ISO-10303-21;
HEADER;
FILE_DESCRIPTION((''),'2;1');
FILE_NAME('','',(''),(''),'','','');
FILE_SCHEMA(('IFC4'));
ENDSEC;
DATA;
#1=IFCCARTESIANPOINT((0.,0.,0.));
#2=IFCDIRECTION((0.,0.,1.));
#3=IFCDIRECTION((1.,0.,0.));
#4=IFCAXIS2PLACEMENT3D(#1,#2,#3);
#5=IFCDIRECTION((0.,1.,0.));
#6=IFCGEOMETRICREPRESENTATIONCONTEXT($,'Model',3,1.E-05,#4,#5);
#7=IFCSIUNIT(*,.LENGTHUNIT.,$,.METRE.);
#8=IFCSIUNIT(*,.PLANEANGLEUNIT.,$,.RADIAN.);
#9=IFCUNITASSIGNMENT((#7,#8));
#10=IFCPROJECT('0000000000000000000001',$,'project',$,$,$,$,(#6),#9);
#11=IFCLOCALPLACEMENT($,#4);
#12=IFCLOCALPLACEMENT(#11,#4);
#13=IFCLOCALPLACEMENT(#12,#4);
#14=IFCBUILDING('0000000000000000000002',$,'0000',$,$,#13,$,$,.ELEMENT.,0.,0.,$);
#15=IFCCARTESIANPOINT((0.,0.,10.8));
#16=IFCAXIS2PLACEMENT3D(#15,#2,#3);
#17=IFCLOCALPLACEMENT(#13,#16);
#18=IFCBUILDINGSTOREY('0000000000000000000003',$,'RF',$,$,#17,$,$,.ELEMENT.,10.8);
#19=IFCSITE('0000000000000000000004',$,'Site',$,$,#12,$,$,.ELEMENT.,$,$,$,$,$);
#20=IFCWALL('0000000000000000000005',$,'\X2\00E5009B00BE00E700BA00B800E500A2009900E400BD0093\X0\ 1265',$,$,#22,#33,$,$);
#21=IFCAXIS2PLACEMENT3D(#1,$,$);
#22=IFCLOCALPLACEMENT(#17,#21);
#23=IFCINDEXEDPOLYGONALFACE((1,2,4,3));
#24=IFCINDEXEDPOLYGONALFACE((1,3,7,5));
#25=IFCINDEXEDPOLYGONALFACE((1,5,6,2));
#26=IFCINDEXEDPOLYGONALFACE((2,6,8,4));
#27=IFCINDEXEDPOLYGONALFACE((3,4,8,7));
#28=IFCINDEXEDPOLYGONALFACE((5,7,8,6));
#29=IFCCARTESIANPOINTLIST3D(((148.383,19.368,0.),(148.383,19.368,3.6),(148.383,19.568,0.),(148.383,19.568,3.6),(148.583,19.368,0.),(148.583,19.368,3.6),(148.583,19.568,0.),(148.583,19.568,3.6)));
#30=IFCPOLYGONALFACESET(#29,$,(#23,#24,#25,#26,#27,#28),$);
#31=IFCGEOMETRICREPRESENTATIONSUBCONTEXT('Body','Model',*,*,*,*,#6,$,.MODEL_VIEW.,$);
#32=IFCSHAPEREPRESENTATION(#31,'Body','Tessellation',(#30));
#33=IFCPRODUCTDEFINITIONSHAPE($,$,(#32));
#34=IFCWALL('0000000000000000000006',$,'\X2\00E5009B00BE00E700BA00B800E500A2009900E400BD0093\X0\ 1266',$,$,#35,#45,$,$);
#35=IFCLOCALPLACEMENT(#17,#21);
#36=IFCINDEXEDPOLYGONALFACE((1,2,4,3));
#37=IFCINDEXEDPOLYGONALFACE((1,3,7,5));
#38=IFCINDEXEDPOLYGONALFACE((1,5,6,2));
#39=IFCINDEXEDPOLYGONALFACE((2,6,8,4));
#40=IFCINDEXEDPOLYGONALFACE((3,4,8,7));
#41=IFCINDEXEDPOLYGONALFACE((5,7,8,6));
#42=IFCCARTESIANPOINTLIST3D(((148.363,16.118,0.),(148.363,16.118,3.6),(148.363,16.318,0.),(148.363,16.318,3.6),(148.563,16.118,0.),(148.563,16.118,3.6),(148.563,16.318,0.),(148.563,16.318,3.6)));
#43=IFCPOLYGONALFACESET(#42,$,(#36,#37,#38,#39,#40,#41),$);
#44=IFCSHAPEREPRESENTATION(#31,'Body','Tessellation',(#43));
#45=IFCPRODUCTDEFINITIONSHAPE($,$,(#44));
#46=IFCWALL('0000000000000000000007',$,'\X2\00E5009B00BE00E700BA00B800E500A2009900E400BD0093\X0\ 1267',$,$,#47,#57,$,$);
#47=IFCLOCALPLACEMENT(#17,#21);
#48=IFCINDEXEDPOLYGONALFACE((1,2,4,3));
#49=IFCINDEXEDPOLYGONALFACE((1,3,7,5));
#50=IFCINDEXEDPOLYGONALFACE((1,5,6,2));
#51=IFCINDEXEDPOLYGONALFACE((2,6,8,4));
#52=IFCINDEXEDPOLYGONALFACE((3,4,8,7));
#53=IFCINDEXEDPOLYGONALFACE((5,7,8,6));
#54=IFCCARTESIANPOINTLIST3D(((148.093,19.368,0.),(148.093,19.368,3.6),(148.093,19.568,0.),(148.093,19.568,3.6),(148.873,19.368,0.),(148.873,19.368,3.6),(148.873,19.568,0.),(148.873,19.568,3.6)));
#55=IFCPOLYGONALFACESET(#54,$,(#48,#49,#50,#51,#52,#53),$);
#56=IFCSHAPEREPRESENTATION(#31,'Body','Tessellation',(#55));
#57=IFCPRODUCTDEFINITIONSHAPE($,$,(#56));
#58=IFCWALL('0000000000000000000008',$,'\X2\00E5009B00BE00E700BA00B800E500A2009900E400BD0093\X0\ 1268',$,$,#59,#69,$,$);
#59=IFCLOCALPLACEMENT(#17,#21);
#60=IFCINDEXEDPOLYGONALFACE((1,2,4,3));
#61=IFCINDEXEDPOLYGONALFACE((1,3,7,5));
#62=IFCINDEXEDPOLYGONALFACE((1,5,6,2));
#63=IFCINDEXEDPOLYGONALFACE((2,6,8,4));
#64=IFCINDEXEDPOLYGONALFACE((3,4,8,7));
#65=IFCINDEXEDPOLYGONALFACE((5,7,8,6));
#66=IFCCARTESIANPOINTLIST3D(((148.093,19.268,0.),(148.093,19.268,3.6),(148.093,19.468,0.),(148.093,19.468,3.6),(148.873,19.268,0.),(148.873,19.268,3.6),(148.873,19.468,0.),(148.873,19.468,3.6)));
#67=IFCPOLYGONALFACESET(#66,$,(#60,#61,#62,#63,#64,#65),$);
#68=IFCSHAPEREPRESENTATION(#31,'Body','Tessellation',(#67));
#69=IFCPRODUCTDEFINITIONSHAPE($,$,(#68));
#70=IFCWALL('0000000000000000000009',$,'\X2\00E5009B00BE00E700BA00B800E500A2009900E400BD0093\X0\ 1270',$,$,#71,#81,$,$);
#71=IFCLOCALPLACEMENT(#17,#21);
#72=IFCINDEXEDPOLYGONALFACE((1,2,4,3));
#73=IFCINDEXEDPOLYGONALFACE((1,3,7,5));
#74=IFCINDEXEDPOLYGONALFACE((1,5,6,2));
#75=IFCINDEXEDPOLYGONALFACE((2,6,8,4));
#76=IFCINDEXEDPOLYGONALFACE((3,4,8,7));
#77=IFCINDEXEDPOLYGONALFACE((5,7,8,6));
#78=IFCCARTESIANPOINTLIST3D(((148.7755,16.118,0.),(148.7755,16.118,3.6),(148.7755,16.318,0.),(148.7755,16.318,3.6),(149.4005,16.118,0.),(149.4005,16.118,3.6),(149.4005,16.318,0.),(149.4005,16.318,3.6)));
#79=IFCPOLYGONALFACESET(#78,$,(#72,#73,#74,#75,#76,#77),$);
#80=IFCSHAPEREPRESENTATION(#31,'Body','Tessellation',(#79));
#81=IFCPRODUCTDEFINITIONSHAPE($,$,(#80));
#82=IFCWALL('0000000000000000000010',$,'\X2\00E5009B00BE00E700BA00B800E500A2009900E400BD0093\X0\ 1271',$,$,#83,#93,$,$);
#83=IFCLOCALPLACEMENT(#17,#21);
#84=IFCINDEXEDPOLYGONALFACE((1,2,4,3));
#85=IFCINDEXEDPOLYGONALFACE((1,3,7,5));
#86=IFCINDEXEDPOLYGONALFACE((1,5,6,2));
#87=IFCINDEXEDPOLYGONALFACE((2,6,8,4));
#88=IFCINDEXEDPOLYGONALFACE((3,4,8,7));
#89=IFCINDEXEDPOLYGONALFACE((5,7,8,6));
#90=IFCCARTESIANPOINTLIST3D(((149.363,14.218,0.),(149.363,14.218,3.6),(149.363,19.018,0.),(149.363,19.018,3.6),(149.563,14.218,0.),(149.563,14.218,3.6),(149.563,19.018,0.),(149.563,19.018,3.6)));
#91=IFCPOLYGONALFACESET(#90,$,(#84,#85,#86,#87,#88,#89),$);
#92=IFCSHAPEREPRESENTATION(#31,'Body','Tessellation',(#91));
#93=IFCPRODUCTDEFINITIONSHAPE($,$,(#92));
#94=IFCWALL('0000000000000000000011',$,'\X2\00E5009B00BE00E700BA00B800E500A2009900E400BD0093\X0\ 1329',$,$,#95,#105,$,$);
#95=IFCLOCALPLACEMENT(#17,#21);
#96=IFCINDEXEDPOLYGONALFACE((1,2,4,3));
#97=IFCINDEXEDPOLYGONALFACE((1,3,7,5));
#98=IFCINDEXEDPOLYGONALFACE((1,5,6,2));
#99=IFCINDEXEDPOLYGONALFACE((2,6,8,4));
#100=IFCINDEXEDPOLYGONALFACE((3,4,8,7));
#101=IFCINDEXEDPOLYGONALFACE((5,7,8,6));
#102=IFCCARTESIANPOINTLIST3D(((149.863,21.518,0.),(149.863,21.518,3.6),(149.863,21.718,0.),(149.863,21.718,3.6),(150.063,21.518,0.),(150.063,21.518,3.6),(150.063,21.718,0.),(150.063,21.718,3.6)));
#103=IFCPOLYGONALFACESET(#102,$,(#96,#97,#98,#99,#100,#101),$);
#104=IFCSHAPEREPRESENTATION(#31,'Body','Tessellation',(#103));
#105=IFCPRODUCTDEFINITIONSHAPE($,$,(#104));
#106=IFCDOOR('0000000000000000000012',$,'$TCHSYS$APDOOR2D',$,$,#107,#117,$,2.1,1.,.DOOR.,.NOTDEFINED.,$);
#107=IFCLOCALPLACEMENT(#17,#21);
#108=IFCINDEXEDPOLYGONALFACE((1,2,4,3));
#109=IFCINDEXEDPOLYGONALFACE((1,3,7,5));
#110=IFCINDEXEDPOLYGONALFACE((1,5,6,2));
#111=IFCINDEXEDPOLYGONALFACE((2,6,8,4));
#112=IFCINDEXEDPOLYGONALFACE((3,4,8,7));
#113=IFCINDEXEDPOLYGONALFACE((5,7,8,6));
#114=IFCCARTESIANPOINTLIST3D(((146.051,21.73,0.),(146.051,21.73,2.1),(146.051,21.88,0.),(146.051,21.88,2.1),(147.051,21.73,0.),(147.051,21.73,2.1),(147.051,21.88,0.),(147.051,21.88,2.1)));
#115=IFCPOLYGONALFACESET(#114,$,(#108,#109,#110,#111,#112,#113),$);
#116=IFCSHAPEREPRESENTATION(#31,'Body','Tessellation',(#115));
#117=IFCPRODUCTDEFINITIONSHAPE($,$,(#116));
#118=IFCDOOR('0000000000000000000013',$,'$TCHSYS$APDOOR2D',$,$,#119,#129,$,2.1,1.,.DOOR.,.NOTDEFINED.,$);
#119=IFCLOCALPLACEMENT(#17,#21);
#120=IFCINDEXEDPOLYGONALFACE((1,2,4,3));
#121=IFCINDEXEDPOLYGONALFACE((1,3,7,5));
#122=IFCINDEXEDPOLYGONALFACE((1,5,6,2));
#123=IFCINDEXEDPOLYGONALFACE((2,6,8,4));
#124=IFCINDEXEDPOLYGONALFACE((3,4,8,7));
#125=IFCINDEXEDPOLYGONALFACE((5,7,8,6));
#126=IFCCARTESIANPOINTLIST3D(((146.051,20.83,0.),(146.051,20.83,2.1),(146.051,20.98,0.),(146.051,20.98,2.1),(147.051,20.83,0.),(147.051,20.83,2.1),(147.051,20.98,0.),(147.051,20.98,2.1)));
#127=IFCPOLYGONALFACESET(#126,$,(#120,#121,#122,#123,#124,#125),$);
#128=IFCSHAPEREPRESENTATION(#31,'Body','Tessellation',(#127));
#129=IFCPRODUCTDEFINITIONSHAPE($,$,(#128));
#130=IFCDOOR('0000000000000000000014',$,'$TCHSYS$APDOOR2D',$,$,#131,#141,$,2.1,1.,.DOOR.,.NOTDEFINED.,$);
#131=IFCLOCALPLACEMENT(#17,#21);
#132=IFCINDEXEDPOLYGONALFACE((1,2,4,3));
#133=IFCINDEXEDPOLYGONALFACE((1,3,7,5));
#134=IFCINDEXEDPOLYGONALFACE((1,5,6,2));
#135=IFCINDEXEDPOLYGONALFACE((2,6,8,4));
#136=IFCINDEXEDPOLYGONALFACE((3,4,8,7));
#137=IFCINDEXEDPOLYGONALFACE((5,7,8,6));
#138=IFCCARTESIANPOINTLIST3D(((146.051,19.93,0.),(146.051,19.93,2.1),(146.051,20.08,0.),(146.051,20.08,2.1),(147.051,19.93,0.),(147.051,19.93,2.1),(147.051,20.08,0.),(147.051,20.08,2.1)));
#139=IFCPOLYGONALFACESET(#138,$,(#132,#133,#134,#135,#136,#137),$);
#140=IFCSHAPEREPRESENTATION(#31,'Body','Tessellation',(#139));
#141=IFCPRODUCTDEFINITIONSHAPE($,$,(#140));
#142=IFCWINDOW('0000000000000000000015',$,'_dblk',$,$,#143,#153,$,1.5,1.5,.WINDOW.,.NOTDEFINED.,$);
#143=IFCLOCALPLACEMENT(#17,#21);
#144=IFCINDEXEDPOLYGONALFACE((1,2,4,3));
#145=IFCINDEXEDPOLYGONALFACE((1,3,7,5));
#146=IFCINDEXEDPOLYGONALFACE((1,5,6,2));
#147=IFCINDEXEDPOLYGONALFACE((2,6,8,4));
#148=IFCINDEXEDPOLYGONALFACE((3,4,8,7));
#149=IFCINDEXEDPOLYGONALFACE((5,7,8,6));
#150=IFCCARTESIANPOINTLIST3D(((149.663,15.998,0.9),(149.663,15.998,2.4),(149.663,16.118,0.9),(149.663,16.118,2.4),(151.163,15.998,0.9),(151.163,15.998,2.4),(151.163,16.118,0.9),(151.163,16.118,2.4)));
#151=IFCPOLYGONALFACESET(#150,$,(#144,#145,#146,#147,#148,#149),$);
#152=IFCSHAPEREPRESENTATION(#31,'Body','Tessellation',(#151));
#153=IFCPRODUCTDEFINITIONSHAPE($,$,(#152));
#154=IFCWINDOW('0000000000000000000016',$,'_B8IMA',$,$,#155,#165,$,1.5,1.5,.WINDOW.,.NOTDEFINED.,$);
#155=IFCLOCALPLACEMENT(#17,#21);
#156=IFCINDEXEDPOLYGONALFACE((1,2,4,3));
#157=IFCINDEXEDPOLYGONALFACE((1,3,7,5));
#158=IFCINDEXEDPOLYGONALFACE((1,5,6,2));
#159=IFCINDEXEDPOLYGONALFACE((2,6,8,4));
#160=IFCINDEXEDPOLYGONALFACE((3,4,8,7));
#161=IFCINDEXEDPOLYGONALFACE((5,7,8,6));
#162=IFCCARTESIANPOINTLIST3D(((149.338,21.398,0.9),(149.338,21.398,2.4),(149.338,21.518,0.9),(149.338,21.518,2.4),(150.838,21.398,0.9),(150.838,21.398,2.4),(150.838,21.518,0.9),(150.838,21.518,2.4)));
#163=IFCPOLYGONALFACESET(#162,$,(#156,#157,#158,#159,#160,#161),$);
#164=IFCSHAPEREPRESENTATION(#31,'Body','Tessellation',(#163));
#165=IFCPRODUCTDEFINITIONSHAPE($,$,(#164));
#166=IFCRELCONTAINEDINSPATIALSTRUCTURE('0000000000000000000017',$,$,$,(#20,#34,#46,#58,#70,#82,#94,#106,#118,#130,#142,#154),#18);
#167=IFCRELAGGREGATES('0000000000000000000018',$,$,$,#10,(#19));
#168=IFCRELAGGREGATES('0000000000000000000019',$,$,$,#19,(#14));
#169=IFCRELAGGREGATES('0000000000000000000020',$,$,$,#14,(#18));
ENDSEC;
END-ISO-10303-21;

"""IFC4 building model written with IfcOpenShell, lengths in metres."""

from ifc_helpers import new_model, si_unit, direction, frame, frame_2d, origin_with_axes, place, context, subcontext, project, spatial, rectangle, extrude, element, save


model = new_model("IFC4")

# Units and contexts
model_context = context("Model", 3, precision=1e-05, world=origin_with_axes(), true_north=direction((0.0, 1.0, 0.0)))
body_context = subcontext(model_context, "Body", "Model", "MODEL_VIEW")
ifc_project = project(units=[si_unit("LENGTHUNIT", "METRE"), si_unit("PLANEANGLEUNIT", "RADIAN")], contexts=[model_context])

# Site, building, storey
placement = place(None, origin_with_axes())
site_placement = place(placement, origin_with_axes())
site = spatial("IfcSite", under=ifc_project, at=site_placement, Name="Site", CompositionType="ELEMENT")
building_placement = place(site_placement, origin_with_axes())
building = spatial("IfcBuilding", under=site, at=building_placement, Name="0000", CompositionType="ELEMENT", ElevationOfRefHeight=0.0, ElevationOfTerrain=0.0)
storey_placement = place(building_placement, frame((0.0, 0.0, 10.8), z_axis=(0.0, 0.0, 1.0), x_axis=(1.0, 0.0, 0.0)))
storey = spatial("IfcBuildingStorey", under=building, at=storey_placement, Name="RF", CompositionType="ELEMENT", Elevation=10.8)

# Walls
for number, where, z_axis, x_axis, name in (
    (1, (148.483, 19.468, 0.0), (0.0, 0.0, 1.0), (0.0, -1.0, 0.0), "å\u009b¾çº¸å¢\u0099ä½\u0093 1265"),
    (2, (148.463, 16.218, 0.0), (0.0, 0.0, 1.0), (0.0, -1.0, 0.0), "å\u009b¾çº¸å¢\u0099ä½\u0093 1266"),
):
    element("IfcWall", number, at=place(storey_placement, frame(where, z_axis=z_axis, x_axis=x_axis)), inside=storey, Name=name, context=body_context, shape_type="SweptSolid", body=[
        extrude(rectangle(XDim=0.2, YDim=0.2, at=frame_2d((0.0, 0.0), x_axis=(1.0, 0.0, 0.0))), frame((0.0, 0.0, 0.0), z_axis=(0.0, 0.0, 1.0)), (0.0, 0.0, 1.0), 3.6),
    ])
for number, where, z_axis, x_axis, name in (
    (3, (148.483, 19.468, 0.0), (0.0, 0.0, 1.0), (1.0, 0.0, 0.0), "å\u009b¾çº¸å¢\u0099ä½\u0093 1267"),
    (4, (148.483, 19.368, 0.0), (0.0, 0.0, 1.0), (1.0, 0.0, 0.0), "å\u009b¾çº¸å¢\u0099ä½\u0093 1268"),
):
    element("IfcWall", number, at=place(storey_placement, frame(where, z_axis=z_axis, x_axis=x_axis)), inside=storey, Name=name, context=body_context, shape_type="SweptSolid", body=[
        extrude(rectangle(XDim=0.78, YDim=0.2, at=frame_2d((0.0, 0.0), x_axis=(1.0, 0.0, 0.0))), frame((0.0, 0.0, 0.0), z_axis=(0.0, 0.0, 1.0)), (0.0, 0.0, 1.0), 3.6),
    ])
wall_1_placement = place(storey_placement, frame((149.088, 16.218, 0.0), z_axis=(0.0, 0.0, 1.0), x_axis=(-1.0, 0.0, 0.0)))
element("IfcWall", 5, at=wall_1_placement, inside=storey, Name="å\u009b¾çº¸å¢\u0099ä½\u0093 1270", context=body_context, shape_type="SweptSolid", body=[
    extrude(rectangle(XDim=0.625, YDim=0.2, at=frame_2d((0.0, 0.0), x_axis=(1.0, 0.0, 0.0))), frame((0.0, 0.0, 0.0), z_axis=(0.0, 0.0, 1.0)), (0.0, 0.0, 1.0), 3.6),
])
wall_2_placement = place(storey_placement, frame((149.463, 16.618, 0.0), z_axis=(0.0, 0.0, 1.0), x_axis=(0.0, 1.0, 0.0)))
element("IfcWall", 6, at=wall_2_placement, inside=storey, Name="å\u009b¾çº¸å¢\u0099ä½\u0093 1271", context=body_context, shape_type="SweptSolid", body=[
    extrude(rectangle(XDim=4.8, YDim=0.2, at=frame_2d((0.0, 0.0), x_axis=(1.0, 0.0, 0.0))), frame((0.0, 0.0, 0.0), z_axis=(0.0, 0.0, 1.0)), (0.0, 0.0, 1.0), 3.6),
])
wall_3_placement = place(storey_placement, frame((149.963, 21.618, 0.0), z_axis=(0.0, 0.0, 1.0), x_axis=(0.0, -1.0, 0.0)))
element("IfcWall", 7, at=wall_3_placement, inside=storey, Name="å\u009b¾çº¸å¢\u0099ä½\u0093 1329", context=body_context, shape_type="SweptSolid", body=[
    extrude(rectangle(XDim=0.2, YDim=0.2, at=frame_2d((0.0, 0.0), x_axis=(1.0, 0.0, 0.0))), frame((0.0, 0.0, 0.0), z_axis=(0.0, 0.0, 1.0)), (0.0, 0.0, 1.0), 3.6),
])

# Doors
for number, where, z_axis, x_axis, name in (
    (8, (146.551, 21.805, 0.0), (0.0, 0.0, 1.0), (1.0, 0.0, 0.0), "$TCHSYS$APDOOR2D"),
    (9, (146.551, 20.905, 0.0), (0.0, 0.0, 1.0), (1.0, 0.0, 0.0), "$TCHSYS$APDOOR2D"),
    (10, (146.551, 20.005, 0.0), (0.0, 0.0, 1.0), (1.0, 0.0, 0.0), "$TCHSYS$APDOOR2D"),
):
    element("IfcDoor", number, at=place(storey_placement, frame(where, z_axis=z_axis, x_axis=x_axis)), inside=storey, Name=name, OperationType="NOTDEFINED", OverallHeight=2.1, OverallWidth=1.0, PredefinedType="DOOR", context=body_context, shape_type="SweptSolid", body=[
        extrude(rectangle(XDim=1.0, YDim=0.15, at=frame_2d((0.0, 0.0), x_axis=(1.0, 0.0, 0.0))), frame((0.0, 0.0, 0.0), z_axis=(0.0, 0.0, 1.0)), (0.0, 0.0, 1.0), 2.1),
    ])

# Windows
for number, where, z_axis, x_axis, name in (
    (11, (150.413, 16.058, 0.9), (0.0, 0.0, 1.0), (1.0, 0.0, 0.0), "_dblk"),
    (12, (150.088, 21.458, 0.9), (0.0, 0.0, 1.0), (1.0, 0.0, 0.0), "_B8IMA"),
):
    element("IfcWindow", number, at=place(storey_placement, frame(where, z_axis=z_axis, x_axis=x_axis)), inside=storey, Name=name, OverallHeight=1.5, OverallWidth=1.5, PartitioningType="NOTDEFINED", PredefinedType="WINDOW", context=body_context, shape_type="SweptSolid", body=[
        extrude(rectangle(XDim=1.5, YDim=0.12, at=frame_2d((0.0, 0.0), x_axis=(1.0, 0.0, 0.0))), frame((0.0, 0.0, 0.0), z_axis=(0.0, 0.0, 1.0)), (0.0, 0.0, 1.0), 1.5),
    ])

save(model, "model.ifc")
